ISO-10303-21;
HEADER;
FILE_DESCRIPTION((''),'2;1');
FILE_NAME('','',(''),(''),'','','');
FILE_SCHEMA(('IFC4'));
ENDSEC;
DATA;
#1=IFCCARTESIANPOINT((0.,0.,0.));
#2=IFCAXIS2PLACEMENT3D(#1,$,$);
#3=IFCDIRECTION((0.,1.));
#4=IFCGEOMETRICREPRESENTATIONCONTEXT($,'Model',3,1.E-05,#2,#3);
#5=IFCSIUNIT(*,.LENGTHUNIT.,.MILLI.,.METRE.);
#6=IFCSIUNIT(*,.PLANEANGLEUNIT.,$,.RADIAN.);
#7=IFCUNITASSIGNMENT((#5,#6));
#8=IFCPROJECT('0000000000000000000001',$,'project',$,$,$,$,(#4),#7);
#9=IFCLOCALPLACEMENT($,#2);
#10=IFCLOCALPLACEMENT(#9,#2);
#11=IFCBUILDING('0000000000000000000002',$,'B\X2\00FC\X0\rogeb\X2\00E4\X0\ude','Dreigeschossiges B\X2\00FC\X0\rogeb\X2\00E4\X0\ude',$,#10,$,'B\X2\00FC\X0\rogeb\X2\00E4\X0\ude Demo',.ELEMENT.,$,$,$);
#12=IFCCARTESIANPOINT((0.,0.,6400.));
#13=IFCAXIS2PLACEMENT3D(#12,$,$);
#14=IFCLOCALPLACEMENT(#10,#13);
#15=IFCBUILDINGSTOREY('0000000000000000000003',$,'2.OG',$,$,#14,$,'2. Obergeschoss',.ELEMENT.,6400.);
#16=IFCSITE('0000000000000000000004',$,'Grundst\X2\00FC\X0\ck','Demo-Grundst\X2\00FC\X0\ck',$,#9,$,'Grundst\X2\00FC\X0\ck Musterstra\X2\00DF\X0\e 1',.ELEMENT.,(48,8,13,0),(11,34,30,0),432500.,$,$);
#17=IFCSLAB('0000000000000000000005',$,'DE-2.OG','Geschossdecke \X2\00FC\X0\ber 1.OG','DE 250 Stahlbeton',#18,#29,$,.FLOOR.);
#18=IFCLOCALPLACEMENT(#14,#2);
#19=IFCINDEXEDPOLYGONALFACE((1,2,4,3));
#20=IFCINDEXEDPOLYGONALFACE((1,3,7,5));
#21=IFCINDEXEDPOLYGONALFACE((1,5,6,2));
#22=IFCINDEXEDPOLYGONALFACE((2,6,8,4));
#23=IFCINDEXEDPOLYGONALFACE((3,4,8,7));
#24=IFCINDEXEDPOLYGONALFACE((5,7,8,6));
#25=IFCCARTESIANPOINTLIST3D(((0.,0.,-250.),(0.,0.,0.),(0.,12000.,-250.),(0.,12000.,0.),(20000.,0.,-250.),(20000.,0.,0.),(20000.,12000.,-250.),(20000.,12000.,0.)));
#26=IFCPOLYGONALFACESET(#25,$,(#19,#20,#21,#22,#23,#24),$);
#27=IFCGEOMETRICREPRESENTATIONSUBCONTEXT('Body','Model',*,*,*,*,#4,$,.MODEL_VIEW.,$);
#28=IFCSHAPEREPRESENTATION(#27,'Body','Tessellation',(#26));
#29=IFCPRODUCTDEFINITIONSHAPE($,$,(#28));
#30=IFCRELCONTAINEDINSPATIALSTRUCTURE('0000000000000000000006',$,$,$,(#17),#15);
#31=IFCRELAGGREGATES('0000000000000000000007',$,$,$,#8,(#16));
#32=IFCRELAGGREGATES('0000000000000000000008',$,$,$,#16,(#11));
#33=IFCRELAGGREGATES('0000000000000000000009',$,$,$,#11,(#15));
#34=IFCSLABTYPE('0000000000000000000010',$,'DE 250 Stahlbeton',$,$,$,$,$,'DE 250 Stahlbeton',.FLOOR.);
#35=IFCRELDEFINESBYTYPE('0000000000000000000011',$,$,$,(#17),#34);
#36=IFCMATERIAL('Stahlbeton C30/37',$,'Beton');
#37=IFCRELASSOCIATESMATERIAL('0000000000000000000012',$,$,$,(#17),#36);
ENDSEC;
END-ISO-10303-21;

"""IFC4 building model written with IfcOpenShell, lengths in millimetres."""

from ifc_helpers import new_model, si_unit, direction, frame, frame_2d, origin, place, context, subcontext, project, spatial, rectangle, extrude, material, type_object, element, save


model = new_model("IFC4")

# Units and contexts
model_context = context("Model", 3, precision=1e-05, world=origin(), true_north=direction((0.0, 1.0)))
body_context = subcontext(model_context, "Body", "Model", "MODEL_VIEW")
ifc_project = project(units=[si_unit("LENGTHUNIT", "METRE", prefix="MILLI"), si_unit("PLANEANGLEUNIT", "RADIAN")], contexts=[model_context])

# Site, building, storey
site_placement = place(None, origin())
site = spatial("IfcSite", under=ifc_project, at=site_placement, Name="Grundstück", Description="Demo-Grundstück", LongName="Grundstück Musterstraße 1", CompositionType="ELEMENT", RefLatitude=(48, 8, 13, 0), RefLongitude=(11, 34, 30, 0), RefElevation=432500.0)
building_placement = place(site_placement, origin())
building = spatial("IfcBuilding", under=site, at=building_placement, Name="Bürogebäude", Description="Dreigeschossiges Bürogebäude", LongName="Bürogebäude Demo", CompositionType="ELEMENT")
storey_placement = place(building_placement, frame((0.0, 0.0, 6400.0)))
storey = spatial("IfcBuildingStorey", under=building, at=storey_placement, Name="2.OG", LongName="2. Obergeschoss", CompositionType="ELEMENT", Elevation=6400.0)

# Slab
ifc_material_1 = material(Name="Stahlbeton C30/37", Category="Beton")
slab_type = type_object("IfcSlabType", Name="DE 250 Stahlbeton", ElementType="DE 250 Stahlbeton", PredefinedType="FLOOR")
slab_placement = place(storey_placement, origin())
element("IfcSlab", 1, at=slab_placement, inside=storey, type_object=slab_type, material=ifc_material_1, Name="DE-2.OG", Description="Geschossdecke über 1.OG", ObjectType="DE 250 Stahlbeton", PredefinedType="FLOOR", context=body_context, shape_type="SweptSolid", body=[
    extrude(rectangle(XDim=20000.0, YDim=12000.0, at=frame_2d((10000.0, 6000.0))), frame((0.0, 0.0, -250.0)), (0.0, 0.0, 1.0), 250.0),
])

save(model, "model.ifc")
